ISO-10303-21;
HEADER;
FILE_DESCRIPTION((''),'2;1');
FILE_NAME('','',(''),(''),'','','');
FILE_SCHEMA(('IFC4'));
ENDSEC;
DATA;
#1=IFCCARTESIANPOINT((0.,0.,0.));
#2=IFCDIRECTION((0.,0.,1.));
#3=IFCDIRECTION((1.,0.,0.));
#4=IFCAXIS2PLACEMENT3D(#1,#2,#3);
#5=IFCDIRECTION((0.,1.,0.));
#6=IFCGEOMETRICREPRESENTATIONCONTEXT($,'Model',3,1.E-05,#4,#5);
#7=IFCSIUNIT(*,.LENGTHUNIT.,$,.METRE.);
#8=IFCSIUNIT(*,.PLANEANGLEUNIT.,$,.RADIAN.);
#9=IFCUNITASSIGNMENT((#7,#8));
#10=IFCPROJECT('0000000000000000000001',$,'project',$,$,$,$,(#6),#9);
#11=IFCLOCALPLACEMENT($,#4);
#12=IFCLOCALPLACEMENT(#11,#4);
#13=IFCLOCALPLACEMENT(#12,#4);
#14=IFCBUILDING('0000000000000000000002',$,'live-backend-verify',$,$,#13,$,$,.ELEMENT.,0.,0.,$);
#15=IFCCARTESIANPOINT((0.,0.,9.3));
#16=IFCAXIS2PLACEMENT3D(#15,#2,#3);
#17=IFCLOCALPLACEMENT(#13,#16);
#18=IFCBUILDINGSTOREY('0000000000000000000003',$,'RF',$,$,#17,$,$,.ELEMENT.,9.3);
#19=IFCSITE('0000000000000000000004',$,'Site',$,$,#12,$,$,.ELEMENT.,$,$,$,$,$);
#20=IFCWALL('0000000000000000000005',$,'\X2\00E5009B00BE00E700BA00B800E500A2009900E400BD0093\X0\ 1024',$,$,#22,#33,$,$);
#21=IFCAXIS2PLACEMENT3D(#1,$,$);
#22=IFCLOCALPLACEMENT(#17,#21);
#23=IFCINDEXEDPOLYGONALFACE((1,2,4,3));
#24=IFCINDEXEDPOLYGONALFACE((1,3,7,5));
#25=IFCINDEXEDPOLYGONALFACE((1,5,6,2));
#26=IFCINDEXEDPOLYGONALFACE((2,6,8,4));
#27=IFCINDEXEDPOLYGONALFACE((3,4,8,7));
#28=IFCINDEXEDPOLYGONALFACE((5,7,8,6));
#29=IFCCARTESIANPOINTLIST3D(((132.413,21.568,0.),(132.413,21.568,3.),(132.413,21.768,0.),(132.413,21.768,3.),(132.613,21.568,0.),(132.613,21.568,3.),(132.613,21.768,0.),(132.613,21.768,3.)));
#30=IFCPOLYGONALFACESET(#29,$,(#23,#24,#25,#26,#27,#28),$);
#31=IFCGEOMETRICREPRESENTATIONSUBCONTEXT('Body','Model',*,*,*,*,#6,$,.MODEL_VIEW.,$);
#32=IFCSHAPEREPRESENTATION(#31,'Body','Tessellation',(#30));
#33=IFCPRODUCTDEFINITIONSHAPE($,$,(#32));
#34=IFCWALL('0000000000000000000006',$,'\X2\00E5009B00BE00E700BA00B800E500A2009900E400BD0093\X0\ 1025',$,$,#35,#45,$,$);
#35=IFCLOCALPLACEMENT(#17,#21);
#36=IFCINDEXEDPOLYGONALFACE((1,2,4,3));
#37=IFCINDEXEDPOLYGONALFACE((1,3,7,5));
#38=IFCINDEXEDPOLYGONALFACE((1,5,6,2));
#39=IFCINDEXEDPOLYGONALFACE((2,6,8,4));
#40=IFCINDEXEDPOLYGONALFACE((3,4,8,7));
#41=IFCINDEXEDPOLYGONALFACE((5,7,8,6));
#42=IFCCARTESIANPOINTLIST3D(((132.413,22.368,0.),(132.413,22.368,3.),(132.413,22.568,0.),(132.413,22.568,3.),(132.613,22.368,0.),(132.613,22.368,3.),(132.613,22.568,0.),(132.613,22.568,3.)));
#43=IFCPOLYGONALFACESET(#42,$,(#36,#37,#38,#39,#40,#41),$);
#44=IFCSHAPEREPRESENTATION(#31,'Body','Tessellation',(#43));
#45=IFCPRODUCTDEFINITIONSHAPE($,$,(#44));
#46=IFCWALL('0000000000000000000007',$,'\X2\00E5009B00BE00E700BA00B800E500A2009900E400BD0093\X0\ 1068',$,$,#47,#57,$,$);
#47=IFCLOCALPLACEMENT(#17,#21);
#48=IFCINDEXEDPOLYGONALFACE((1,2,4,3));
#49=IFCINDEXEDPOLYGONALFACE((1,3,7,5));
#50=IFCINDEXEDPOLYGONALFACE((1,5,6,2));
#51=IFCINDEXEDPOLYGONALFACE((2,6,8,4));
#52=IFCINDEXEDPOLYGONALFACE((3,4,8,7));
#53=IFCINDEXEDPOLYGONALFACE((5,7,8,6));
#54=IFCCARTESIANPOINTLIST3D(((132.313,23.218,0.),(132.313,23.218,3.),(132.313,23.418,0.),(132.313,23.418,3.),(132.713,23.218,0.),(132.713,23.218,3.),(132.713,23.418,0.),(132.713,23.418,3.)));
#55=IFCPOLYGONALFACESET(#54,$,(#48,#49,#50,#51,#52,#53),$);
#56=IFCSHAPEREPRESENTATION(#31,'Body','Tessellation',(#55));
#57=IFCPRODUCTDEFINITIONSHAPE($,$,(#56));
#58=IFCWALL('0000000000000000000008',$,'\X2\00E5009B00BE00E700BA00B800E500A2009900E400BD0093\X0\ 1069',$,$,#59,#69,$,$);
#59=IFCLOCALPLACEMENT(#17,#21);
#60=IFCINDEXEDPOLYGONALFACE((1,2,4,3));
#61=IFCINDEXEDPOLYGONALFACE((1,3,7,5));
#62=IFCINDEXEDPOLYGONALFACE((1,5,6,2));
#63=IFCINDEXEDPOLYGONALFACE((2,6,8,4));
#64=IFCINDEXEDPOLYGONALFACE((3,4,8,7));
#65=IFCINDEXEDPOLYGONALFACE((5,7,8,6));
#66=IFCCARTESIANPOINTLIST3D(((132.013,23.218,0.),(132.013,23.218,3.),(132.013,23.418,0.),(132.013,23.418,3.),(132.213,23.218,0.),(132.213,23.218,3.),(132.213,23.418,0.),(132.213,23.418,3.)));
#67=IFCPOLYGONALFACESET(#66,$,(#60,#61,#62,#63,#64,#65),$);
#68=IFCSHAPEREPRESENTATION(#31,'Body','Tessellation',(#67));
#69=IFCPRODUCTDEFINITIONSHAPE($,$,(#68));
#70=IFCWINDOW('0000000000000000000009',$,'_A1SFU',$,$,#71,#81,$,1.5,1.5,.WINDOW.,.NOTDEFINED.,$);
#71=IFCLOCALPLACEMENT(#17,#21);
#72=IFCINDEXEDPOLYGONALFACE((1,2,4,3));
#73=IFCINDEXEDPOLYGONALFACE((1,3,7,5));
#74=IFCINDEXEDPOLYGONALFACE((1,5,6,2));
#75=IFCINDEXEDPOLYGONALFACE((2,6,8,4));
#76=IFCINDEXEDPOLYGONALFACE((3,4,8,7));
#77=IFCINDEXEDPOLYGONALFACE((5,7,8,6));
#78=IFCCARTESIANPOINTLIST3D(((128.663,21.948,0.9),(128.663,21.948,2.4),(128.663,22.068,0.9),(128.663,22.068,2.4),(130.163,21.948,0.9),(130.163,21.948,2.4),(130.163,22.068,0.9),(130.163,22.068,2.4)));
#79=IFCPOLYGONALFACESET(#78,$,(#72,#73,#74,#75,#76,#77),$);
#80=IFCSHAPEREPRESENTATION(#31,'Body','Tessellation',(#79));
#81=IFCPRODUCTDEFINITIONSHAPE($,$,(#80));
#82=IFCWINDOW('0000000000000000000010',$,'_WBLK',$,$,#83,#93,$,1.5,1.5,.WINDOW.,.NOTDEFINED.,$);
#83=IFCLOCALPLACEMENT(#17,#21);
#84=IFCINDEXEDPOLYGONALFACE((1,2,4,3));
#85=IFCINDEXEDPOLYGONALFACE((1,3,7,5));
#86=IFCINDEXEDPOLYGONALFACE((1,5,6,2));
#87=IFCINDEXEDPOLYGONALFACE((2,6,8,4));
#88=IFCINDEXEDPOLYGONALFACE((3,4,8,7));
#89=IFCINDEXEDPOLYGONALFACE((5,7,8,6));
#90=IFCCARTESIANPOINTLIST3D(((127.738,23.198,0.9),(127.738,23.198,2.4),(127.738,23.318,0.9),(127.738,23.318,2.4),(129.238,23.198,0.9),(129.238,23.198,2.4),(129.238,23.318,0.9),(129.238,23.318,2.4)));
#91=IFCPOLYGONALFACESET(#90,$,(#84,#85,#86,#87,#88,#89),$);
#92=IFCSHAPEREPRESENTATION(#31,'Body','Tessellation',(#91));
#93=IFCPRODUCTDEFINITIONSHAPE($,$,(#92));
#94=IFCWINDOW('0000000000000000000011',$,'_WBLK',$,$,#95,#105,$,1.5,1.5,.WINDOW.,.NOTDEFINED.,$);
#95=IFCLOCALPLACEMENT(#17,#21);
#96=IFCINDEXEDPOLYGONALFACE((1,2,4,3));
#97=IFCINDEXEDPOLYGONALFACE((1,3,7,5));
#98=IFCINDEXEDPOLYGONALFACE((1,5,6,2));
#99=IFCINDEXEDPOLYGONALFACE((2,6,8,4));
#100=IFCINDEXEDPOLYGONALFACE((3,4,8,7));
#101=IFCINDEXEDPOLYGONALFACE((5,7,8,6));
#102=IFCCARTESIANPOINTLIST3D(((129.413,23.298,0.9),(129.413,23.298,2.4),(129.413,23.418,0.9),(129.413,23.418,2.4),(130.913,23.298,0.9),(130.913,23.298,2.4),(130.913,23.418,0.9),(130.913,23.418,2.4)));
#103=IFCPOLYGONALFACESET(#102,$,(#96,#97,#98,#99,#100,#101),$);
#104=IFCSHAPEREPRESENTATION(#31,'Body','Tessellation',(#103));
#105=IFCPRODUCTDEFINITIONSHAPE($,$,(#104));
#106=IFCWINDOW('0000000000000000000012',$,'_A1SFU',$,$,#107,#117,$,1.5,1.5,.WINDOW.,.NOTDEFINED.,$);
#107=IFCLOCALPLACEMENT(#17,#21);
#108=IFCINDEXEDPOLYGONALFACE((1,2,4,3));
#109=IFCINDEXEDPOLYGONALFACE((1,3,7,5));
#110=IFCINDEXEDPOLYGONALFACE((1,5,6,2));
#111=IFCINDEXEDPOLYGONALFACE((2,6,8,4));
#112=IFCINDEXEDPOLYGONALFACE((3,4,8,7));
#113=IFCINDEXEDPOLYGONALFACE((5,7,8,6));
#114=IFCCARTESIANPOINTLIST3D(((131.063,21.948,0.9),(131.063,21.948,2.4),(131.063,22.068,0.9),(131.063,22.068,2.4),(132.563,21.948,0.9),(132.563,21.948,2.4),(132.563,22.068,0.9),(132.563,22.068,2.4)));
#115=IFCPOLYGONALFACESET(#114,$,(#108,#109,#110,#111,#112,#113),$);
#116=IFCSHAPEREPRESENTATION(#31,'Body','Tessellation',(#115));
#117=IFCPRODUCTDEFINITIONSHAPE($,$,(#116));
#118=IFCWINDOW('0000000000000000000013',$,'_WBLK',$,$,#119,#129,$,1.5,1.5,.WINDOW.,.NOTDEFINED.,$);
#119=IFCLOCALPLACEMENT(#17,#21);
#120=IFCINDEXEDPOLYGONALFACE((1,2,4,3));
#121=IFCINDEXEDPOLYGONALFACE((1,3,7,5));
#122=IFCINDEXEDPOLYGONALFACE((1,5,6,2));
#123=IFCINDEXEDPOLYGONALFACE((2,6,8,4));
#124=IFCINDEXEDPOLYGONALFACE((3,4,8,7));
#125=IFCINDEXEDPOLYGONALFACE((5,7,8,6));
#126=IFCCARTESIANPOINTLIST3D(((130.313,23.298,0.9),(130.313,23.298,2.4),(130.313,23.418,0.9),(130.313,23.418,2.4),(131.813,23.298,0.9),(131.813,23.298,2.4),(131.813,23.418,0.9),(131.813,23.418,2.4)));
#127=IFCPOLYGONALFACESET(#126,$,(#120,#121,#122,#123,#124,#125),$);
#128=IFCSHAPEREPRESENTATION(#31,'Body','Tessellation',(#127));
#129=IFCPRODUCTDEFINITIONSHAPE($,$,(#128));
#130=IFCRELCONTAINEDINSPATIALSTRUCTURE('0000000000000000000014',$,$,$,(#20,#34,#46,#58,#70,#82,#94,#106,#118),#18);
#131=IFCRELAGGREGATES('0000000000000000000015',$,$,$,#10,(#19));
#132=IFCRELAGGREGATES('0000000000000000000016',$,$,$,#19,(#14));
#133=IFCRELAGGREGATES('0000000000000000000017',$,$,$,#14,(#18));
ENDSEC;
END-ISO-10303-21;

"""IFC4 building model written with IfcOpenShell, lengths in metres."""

from ifc_helpers import new_model, si_unit, direction, frame, frame_2d, origin_with_axes, place, context, subcontext, project, spatial, rectangle, extrude, element, save


model = new_model("IFC4")

# Units and contexts
model_context = context("Model", 3, precision=1e-05, world=origin_with_axes(), true_north=direction((0.0, 1.0, 0.0)))
body_context = subcontext(model_context, "Body", "Model", "MODEL_VIEW")
ifc_project = project(units=[si_unit("LENGTHUNIT", "METRE"), si_unit("PLANEANGLEUNIT", "RADIAN")], contexts=[model_context])

# Site, building, storey
placement = place(None, origin_with_axes())
site_placement = place(placement, origin_with_axes())
site = spatial("IfcSite", under=ifc_project, at=site_placement, Name="Site", CompositionType="ELEMENT")
building_placement = place(site_placement, origin_with_axes())
building = spatial("IfcBuilding", under=site, at=building_placement, Name="live-backend-verify", CompositionType="ELEMENT", ElevationOfRefHeight=0.0, ElevationOfTerrain=0.0)
storey_placement = place(building_placement, frame((0.0, 0.0, 9.3), z_axis=(0.0, 0.0, 1.0), x_axis=(1.0, 0.0, 0.0)))
storey = spatial("IfcBuildingStorey", under=building, at=storey_placement, Name="RF", CompositionType="ELEMENT", Elevation=9.3)

# Walls
for number, where, z_axis, x_axis, name in (
    (1, (132.513, 21.668, 0.0), (0.0, 0.0, 1.0), (0.0, -1.0, 0.0), "å\u009b¾çº¸å¢\u0099ä½\u0093 1024"),
    (2, (132.513, 22.468, 0.0), (0.0, 0.0, 1.0), (1.0, 0.0, 0.0), "å\u009b¾çº¸å¢\u0099ä½\u0093 1025"),
):
    element("IfcWall", number, at=place(storey_placement, frame(where, z_axis=z_axis, x_axis=x_axis)), inside=storey, Name=name, context=body_context, shape_type="SweptSolid", body=[
        extrude(rectangle(XDim=0.2, YDim=0.2, at=frame_2d((0.0, 0.0), x_axis=(1.0, 0.0, 0.0))), frame((0.0, 0.0, 0.0), z_axis=(0.0, 0.0, 1.0)), (0.0, 0.0, 1.0), 3.0),
    ])
wall_1_placement = place(storey_placement, frame((132.513, 23.318, 0.0), z_axis=(0.0, 0.0, 1.0), x_axis=(-1.0, 0.0, 0.0)))
element("IfcWall", 3, at=wall_1_placement, inside=storey, Name="å\u009b¾çº¸å¢\u0099ä½\u0093 1068", context=body_context, shape_type="SweptSolid", body=[
    extrude(rectangle(XDim=0.4, YDim=0.2, at=frame_2d((0.0, 0.0), x_axis=(1.0, 0.0, 0.0))), frame((0.0, 0.0, 0.0), z_axis=(0.0, 0.0, 1.0)), (0.0, 0.0, 1.0), 3.0),
])
for number, where, z_axis, x_axis, name in (
    (4, (132.113, 23.318, 0.0), (0.0, 0.0, 1.0), (0.0, 1.0, 0.0), "å\u009b¾çº¸å¢\u0099ä½\u0093 1069"),
):
    element("IfcWall", number, at=place(storey_placement, frame(where, z_axis=z_axis, x_axis=x_axis)), inside=storey, Name=name, context=body_context, shape_type="SweptSolid", body=[
        extrude(rectangle(XDim=0.2, YDim=0.2, at=frame_2d((0.0, 0.0), x_axis=(1.0, 0.0, 0.0))), frame((0.0, 0.0, 0.0), z_axis=(0.0, 0.0, 1.0)), (0.0, 0.0, 1.0), 3.0),
    ])

# Windows
for number, where, z_axis, x_axis, name in (
    (5, (129.413, 22.008, 0.9), (0.0, 0.0, 1.0), (1.0, 0.0, 0.0), "_A1SFU"),
    (6, (128.488, 23.258, 0.9), (0.0, 0.0, 1.0), (1.0, 0.0, 0.0), "_WBLK"),
    (7, (130.163, 23.358, 0.9), (0.0, 0.0, 1.0), (1.0, 0.0, 0.0), "_WBLK"),
    (8, (131.813, 22.008, 0.9), (0.0, 0.0, 1.0), (1.0, 0.0, 0.0), "_A1SFU"),
    (9, (131.063, 23.358, 0.9), (0.0, 0.0, 1.0), (1.0, 0.0, 0.0), "_WBLK"),
):
    element("IfcWindow", number, at=place(storey_placement, frame(where, z_axis=z_axis, x_axis=x_axis)), inside=storey, Name=name, OverallHeight=1.5, OverallWidth=1.5, PartitioningType="NOTDEFINED", PredefinedType="WINDOW", context=body_context, shape_type="SweptSolid", body=[
        extrude(rectangle(XDim=1.5, YDim=0.12, at=frame_2d((0.0, 0.0), x_axis=(1.0, 0.0, 0.0))), frame((0.0, 0.0, 0.0), z_axis=(0.0, 0.0, 1.0)), (0.0, 0.0, 1.0), 1.5),
    ])

save(model, "model.ifc")
